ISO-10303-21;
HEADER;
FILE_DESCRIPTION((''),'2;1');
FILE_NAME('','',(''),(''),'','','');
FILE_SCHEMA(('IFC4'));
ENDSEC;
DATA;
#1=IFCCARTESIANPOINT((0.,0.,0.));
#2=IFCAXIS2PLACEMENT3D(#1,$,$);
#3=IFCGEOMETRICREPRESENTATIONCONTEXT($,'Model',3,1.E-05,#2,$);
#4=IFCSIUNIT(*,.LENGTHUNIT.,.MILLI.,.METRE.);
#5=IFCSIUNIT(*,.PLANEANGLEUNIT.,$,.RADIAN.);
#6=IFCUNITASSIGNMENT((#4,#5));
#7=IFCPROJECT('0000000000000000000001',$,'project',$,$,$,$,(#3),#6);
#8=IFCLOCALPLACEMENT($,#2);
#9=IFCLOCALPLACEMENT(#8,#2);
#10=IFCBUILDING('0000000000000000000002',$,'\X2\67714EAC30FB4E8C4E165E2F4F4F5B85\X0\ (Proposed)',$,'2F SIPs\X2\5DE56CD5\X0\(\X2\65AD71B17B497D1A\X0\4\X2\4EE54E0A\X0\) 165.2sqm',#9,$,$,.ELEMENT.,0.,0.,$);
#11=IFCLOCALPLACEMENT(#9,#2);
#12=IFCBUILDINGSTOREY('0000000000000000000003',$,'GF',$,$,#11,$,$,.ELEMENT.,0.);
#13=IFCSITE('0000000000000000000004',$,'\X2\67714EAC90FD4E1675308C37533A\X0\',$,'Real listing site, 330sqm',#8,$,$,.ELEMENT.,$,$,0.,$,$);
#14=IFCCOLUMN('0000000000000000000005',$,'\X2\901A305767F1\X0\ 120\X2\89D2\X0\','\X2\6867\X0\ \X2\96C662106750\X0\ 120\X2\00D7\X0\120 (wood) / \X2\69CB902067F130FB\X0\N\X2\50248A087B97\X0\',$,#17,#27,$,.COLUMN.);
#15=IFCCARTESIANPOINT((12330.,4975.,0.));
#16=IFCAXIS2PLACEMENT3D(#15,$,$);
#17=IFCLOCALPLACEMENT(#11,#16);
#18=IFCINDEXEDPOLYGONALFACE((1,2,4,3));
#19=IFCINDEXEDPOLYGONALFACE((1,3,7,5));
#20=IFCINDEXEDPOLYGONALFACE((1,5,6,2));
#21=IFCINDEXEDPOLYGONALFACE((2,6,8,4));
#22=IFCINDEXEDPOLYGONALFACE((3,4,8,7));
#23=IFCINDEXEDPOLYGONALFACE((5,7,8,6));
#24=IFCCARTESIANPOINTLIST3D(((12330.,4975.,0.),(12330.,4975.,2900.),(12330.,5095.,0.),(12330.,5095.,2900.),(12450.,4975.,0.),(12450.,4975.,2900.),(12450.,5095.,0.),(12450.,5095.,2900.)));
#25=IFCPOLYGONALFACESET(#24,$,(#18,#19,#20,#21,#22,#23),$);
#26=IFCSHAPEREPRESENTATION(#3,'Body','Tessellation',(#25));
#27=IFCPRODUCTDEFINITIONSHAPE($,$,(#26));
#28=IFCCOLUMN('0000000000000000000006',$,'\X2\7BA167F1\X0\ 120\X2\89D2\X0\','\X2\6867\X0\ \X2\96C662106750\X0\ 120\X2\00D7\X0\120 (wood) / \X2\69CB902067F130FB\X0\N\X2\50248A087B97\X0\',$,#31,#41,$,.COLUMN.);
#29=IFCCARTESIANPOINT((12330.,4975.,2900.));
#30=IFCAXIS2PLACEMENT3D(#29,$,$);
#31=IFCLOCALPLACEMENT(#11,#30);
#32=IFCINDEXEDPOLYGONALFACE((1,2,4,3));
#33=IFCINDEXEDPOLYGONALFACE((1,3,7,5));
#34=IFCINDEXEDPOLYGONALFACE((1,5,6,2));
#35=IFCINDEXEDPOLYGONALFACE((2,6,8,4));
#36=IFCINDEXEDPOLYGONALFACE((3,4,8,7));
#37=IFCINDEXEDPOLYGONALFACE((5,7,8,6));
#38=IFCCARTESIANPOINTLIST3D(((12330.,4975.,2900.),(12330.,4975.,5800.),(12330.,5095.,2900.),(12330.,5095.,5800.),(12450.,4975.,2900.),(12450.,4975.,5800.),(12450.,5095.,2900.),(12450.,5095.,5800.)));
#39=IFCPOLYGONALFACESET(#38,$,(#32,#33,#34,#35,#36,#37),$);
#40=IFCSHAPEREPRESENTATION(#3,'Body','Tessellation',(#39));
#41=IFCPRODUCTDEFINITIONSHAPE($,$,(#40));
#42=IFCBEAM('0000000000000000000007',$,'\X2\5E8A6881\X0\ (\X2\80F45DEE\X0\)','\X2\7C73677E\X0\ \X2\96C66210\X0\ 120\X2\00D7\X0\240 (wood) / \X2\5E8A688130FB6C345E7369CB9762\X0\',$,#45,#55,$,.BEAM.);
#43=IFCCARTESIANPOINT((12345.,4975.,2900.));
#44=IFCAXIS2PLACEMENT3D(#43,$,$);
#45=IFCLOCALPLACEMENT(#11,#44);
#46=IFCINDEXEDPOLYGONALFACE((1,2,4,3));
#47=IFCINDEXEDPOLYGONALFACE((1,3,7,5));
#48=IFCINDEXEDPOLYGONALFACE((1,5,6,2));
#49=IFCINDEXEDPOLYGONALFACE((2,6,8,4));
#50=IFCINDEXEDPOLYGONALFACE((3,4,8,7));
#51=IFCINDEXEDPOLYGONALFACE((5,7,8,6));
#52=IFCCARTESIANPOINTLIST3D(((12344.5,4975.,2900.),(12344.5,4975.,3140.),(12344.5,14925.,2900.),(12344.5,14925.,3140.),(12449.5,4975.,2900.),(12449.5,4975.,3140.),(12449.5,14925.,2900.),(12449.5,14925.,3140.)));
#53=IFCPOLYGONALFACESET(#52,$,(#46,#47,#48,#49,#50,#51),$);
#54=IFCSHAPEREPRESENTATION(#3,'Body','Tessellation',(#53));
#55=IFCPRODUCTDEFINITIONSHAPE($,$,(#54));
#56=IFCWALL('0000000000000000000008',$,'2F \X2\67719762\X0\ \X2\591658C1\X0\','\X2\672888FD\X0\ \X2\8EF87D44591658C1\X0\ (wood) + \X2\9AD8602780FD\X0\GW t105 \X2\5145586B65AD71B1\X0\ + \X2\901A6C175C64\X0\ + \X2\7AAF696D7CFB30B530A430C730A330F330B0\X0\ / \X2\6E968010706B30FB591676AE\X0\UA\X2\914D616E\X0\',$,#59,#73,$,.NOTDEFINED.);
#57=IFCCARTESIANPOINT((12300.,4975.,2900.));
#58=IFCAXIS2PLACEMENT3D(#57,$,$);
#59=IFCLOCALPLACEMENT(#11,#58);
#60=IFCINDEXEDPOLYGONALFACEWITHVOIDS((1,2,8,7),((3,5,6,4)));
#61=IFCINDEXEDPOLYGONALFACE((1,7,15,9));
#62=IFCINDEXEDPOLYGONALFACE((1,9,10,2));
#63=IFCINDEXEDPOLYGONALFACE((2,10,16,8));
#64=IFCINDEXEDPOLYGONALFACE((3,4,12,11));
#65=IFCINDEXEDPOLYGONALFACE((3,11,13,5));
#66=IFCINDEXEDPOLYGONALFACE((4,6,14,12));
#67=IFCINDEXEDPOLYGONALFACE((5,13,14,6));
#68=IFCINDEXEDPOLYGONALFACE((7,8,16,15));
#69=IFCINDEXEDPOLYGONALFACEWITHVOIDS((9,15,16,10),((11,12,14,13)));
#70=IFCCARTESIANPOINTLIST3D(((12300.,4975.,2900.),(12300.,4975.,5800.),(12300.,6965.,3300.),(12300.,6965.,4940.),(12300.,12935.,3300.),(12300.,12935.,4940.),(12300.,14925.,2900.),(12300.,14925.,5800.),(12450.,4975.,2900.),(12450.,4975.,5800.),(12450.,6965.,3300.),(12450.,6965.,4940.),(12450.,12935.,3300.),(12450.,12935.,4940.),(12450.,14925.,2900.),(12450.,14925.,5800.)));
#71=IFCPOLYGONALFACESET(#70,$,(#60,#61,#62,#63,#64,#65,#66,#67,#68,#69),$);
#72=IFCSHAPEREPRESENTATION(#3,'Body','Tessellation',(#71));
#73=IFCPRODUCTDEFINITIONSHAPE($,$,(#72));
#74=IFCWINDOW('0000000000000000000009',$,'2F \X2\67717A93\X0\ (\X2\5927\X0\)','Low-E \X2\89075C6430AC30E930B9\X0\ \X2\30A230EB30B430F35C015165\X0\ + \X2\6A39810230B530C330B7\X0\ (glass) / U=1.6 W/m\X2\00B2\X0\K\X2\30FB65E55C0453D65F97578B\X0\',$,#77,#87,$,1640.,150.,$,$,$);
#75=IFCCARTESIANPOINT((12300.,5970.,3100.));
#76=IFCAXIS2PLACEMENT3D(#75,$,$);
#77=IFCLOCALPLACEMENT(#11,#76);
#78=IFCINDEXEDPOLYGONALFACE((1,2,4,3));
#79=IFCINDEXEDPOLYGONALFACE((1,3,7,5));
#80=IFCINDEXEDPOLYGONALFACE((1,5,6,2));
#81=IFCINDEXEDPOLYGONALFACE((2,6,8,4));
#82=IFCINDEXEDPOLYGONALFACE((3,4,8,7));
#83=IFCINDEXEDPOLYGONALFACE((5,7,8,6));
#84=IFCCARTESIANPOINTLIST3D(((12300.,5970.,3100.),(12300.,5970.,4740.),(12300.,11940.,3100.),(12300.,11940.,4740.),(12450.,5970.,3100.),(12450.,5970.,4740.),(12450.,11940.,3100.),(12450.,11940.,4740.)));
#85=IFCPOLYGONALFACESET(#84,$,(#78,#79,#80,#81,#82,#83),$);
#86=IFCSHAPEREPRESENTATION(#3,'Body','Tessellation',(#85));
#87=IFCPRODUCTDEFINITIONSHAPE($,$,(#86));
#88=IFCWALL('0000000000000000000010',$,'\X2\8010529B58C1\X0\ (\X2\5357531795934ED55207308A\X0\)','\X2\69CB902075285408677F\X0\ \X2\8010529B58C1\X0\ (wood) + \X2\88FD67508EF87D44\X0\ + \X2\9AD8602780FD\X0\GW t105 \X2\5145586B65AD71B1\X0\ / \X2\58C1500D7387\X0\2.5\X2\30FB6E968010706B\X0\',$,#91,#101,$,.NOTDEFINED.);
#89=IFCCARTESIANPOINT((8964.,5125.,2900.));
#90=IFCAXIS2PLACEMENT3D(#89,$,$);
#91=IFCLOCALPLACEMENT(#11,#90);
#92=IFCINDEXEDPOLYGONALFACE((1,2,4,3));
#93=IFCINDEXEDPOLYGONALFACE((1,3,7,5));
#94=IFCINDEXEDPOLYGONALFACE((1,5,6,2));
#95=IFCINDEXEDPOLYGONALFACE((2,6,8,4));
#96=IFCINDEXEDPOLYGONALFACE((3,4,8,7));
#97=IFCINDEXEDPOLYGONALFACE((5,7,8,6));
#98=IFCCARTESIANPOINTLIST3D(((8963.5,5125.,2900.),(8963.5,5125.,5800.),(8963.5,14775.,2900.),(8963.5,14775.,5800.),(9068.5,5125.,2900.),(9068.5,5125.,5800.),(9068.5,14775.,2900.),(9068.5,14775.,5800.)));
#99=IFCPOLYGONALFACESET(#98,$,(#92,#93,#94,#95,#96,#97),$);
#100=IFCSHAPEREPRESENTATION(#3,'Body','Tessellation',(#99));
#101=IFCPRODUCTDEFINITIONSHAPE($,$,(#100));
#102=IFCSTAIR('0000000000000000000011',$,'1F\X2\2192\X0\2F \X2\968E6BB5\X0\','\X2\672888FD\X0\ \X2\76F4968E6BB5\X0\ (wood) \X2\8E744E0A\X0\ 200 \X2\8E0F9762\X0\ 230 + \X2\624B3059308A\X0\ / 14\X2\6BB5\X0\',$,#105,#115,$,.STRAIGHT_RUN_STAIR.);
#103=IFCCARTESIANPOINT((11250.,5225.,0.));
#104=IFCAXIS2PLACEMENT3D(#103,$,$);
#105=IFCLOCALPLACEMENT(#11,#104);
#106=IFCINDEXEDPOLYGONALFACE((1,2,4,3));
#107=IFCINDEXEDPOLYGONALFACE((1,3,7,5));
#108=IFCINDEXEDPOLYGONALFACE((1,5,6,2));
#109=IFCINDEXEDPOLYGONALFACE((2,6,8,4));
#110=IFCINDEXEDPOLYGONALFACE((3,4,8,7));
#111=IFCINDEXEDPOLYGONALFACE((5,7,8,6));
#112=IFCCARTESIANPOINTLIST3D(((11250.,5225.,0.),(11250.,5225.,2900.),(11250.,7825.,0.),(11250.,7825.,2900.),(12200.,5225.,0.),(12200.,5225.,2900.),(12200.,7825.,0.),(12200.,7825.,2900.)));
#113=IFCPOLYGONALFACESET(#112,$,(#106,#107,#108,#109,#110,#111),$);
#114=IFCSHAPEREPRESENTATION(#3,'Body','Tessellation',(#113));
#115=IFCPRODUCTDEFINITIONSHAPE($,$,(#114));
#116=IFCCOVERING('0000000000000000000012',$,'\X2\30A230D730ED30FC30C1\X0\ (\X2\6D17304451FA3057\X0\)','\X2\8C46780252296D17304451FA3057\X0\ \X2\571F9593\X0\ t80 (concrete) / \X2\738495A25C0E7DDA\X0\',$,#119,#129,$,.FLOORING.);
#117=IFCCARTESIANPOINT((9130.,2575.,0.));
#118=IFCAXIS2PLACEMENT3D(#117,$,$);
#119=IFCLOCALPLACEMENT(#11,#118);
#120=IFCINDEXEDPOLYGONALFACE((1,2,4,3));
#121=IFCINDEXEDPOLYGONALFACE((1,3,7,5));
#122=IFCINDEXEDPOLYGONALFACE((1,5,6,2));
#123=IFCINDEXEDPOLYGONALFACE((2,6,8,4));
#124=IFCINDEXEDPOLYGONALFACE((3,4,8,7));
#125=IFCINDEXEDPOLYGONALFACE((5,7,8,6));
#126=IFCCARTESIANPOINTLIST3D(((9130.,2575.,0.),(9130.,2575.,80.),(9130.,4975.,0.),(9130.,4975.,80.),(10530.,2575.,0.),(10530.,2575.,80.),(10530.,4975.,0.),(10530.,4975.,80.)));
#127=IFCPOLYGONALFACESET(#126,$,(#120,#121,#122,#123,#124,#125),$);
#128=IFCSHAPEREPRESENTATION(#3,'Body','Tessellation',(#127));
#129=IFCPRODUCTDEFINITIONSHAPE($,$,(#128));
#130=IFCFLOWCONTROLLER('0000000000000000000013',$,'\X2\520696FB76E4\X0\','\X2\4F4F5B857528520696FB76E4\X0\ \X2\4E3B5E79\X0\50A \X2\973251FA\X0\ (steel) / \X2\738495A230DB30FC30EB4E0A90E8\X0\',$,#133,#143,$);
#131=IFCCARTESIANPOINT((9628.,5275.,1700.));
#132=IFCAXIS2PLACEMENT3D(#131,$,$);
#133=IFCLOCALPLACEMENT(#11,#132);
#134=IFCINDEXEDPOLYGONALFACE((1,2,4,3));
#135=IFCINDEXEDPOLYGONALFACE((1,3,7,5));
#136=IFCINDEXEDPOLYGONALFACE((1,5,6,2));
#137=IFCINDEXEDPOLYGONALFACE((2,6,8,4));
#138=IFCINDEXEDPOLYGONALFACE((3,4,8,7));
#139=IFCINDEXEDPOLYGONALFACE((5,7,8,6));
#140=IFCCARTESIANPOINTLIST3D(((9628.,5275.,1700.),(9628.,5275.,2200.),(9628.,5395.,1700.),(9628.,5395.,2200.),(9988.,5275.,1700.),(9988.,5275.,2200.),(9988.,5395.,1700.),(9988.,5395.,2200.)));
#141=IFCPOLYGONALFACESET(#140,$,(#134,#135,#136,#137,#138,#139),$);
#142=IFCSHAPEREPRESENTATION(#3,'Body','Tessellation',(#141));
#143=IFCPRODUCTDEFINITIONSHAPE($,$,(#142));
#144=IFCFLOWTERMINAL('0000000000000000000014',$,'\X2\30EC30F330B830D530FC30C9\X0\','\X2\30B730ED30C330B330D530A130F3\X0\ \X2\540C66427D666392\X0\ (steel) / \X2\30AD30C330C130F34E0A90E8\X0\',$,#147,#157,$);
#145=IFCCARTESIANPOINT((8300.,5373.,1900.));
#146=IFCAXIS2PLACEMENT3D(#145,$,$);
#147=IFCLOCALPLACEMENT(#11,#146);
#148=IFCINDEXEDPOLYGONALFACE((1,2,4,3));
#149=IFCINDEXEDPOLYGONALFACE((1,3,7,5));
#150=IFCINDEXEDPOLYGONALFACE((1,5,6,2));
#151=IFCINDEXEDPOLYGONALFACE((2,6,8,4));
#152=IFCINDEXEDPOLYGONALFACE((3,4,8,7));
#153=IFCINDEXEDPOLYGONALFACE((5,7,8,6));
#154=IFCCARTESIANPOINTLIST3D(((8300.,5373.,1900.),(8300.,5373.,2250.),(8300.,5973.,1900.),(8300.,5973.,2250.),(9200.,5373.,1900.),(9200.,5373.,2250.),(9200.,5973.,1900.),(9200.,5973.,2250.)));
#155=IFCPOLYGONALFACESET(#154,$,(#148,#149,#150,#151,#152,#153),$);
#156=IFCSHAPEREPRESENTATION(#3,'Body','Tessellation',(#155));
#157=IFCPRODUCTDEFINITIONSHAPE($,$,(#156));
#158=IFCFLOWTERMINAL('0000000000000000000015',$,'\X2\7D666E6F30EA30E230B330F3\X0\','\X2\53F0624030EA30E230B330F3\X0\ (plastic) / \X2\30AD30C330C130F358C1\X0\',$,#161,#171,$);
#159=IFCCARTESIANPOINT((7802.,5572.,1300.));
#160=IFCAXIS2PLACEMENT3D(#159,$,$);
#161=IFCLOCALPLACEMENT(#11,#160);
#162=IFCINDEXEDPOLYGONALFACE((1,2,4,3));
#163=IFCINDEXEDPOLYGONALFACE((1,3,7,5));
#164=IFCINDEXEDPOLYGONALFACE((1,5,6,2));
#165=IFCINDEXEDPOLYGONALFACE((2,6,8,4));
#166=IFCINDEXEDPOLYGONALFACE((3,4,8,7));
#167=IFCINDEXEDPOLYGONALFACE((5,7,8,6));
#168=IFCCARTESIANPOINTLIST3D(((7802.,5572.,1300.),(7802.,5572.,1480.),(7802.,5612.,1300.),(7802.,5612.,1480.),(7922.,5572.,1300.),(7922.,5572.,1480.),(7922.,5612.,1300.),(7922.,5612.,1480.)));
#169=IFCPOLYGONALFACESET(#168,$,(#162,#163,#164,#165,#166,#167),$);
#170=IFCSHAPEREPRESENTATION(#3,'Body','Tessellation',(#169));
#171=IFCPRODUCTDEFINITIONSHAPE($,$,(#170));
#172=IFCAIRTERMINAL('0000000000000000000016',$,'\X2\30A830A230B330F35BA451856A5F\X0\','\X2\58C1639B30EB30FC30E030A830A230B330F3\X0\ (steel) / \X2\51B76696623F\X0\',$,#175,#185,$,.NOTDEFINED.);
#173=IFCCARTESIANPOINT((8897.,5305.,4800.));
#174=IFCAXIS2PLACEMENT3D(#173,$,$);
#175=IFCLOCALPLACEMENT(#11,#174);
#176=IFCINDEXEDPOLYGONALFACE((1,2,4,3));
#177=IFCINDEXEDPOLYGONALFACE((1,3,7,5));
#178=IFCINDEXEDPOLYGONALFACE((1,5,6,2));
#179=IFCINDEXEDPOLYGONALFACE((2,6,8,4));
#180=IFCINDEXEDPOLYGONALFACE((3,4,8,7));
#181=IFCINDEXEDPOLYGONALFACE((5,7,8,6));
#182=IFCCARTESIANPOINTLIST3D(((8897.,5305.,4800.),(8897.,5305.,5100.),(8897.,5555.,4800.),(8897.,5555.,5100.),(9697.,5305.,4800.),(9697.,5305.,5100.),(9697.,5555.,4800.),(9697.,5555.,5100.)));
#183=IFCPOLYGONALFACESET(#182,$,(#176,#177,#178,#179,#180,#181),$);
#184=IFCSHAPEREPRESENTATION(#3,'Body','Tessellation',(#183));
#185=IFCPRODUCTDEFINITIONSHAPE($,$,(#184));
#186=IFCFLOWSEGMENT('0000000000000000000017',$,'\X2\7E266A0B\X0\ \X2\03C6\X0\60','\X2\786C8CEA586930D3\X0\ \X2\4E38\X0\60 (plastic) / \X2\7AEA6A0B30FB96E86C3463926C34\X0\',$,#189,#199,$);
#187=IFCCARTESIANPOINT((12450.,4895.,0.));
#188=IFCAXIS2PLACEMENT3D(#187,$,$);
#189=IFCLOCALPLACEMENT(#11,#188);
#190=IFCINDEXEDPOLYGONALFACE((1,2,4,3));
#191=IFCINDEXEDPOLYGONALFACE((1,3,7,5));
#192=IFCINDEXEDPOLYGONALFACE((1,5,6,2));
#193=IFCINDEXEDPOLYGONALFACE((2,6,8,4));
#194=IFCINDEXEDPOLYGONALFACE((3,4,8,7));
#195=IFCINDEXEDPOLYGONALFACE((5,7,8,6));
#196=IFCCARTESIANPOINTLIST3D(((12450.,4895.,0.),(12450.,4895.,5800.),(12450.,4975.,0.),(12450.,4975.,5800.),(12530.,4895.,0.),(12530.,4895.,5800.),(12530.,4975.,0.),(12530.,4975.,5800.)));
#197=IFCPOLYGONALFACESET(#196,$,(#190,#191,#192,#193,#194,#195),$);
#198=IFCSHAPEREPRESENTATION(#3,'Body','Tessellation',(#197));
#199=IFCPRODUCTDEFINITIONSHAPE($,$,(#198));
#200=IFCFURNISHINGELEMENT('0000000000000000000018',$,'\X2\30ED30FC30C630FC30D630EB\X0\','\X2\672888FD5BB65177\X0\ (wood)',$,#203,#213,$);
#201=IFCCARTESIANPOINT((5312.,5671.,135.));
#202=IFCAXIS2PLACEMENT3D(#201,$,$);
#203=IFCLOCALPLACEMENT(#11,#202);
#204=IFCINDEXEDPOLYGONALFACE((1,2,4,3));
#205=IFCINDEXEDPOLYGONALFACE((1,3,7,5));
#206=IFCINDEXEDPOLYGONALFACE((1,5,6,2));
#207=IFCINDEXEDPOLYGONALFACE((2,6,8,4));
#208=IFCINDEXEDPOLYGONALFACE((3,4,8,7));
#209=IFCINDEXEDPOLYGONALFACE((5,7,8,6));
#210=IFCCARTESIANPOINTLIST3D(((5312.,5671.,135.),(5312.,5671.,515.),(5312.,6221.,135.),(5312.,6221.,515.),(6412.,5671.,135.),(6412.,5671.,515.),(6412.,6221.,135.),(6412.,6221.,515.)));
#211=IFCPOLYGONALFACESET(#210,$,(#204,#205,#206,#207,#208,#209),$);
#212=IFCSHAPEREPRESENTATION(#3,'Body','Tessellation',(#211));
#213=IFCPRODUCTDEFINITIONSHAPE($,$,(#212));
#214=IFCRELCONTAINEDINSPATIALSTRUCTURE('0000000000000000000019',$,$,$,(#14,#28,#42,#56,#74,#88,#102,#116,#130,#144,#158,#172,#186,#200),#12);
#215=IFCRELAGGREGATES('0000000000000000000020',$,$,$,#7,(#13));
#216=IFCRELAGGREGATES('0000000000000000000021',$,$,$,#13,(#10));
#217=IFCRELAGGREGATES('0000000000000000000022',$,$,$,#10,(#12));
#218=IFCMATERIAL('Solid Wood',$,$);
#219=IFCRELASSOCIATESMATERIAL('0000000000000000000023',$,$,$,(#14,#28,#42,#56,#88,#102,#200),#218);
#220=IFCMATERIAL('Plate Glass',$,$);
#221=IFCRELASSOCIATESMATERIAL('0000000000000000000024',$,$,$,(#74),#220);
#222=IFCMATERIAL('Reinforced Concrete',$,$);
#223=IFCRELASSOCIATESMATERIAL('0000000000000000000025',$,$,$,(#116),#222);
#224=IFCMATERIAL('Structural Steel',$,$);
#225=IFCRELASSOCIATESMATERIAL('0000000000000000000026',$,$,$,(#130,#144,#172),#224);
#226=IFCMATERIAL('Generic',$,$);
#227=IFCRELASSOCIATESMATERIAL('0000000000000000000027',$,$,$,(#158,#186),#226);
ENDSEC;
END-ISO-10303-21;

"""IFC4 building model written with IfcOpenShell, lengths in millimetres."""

from ifc_helpers import new_model, si_unit, frame, frame_2d, origin, place, context, project, spatial, rectangle, extrude, material, element, fill, save


model = new_model("IFC4")

# Units and contexts
model_context = context("Model", 3, precision=1e-05, world=origin())
ifc_project = project(units=[si_unit("LENGTHUNIT", "METRE", prefix="MILLI"), si_unit("PLANEANGLEUNIT", "RADIAN")], contexts=[model_context])

# Site, building, storey
site_placement = place(None, origin())
site = spatial("IfcSite", under=ifc_project, at=site_placement, Name="東京都世田谷区", ObjectType="Real listing site, 330sqm", CompositionType="ELEMENT", RefElevation=0.0)
building_placement = place(site_placement, origin())
building = spatial("IfcBuilding", under=site, at=building_placement, Name="東京・二世帯住宅 (Proposed)", ObjectType="2F SIPs工法(断熱等級4以上) 165.2sqm", CompositionType="ELEMENT", ElevationOfRefHeight=0.0, ElevationOfTerrain=0.0)
storey_placement = place(building_placement, origin())
storey = spatial("IfcBuildingStorey", under=building, at=storey_placement, Name="GF", CompositionType="ELEMENT", Elevation=0.0)

# Columns
ifc_material_1 = material(Name="Solid Wood")
column_1_placement = place(storey_placement, frame((12330.0, 4975.0, 0.0)))
element("IfcColumn", 1, at=column_1_placement, inside=storey, material=ifc_material_1, Name="通し柱 120角", Description="桧 集成材 120×120 (wood) / 構造柱・N値計算", PredefinedType="COLUMN", context=model_context, shape_type="SweptSolid", body=[
    extrude(rectangle(XDim=120.0, YDim=120.0, at=frame_2d((60.0, 60.0))), frame((12330.0, 4975.0, 0.0)), (0.0, 0.0, 1.0), 2900.0),
])
column_2_placement = place(storey_placement, frame((12330.0, 4975.0, 2900.0)))
element("IfcColumn", 2, at=column_2_placement, inside=storey, material=ifc_material_1, Name="管柱 120角", Description="桧 集成材 120×120 (wood) / 構造柱・N値計算", PredefinedType="COLUMN", context=model_context, shape_type="SweptSolid", body=[
    extrude(rectangle(XDim=120.0, YDim=120.0, at=frame_2d((60.0, 60.0))), frame((12330.0, 4975.0, 2900.0)), (0.0, 0.0, 1.0), 2900.0),
])

# Beam
beam_1_placement = place(storey_placement, frame((12345.0, 4975.0, 2900.0)))
element("IfcBeam", 3, at=beam_1_placement, inside=storey, material=ifc_material_1, Name="床梁 (胴差)", Description="米松 集成 120×240 (wood) / 床梁・水平構面", PredefinedType="BEAM", context=model_context, shape_type="SweptSolid", body=[
    extrude(rectangle(XDim=105.0, YDim=9950.0, at=frame_2d((52.0, 4975.0))), frame((12345.0, 4975.0, 2900.0)), (0.0, 0.0, 1.0), 240.0),
])

# Shared definitions
ifc_material_2 = material(Name="Plate Glass")

# Wall, opening, window
wall_1_placement = place(storey_placement, frame((12300.0, 4975.0, 2900.0)))
wall_1 = element("IfcWall", 4, at=wall_1_placement, inside=storey, material=ifc_material_1, Name="2F 東面 外壁", Description="木製 軸組外壁 (wood) + 高性能GW t105 充填断熱 + 通気層 + 窯業系サイディング / 準耐火・外皮UA配慮", PredefinedType="NOTDEFINED", context=model_context, shape_type="SweptSolid", body=[
    extrude(rectangle(XDim=150.0, YDim=9950.0, at=frame_2d((75.0, 4975.0))), frame((12300.0, 4975.0, 2900.0)), (0.0, 0.0, 1.0), 2900.0),
])
opening_1_placement = place(storey_placement, frame((12300.0, 5970.0, 3100.0)))
opening_1 = element("IfcOpeningElement", 5, at=opening_1_placement, cuts=wall_1, PredefinedType="NOTDEFINED", context=model_context, shape_type="SweptSolid", body=[
    extrude(rectangle(XDim=150.0, YDim=5970.0, at=frame_2d((75.0, 2985.0))), frame((12300.0, 5970.0, 3100.0)), (0.0, 0.0, 1.0), 1640.0),
])
window_1_placement = place(storey_placement, frame((12300.0, 5970.0, 3100.0)))
window_1 = element("IfcWindow", 6, at=window_1_placement, inside=storey, material=ifc_material_2, Name="2F 東窓 (大)", Description="Low-E 複層ガラス アルゴン封入 + 樹脂サッシ (glass) / U=1.6 W/m²K・日射取得型", OverallHeight=1640.0, OverallWidth=150.0, context=model_context, shape_type="SweptSolid", body=[
    extrude(rectangle(XDim=150.0, YDim=5970.0, at=frame_2d((75.0, 2985.0))), frame((12300.0, 5970.0, 3100.0)), (0.0, 0.0, 1.0), 1640.0),
])
fill(opening_1, window_1)

# Wall
wall_2_placement = place(storey_placement, frame((8964.0, 5125.0, 2900.0)))
element("IfcWall", 7, at=wall_2_placement, inside=storey, material=ifc_material_1, Name="耐力壁 (南北間仕切り)", Description="構造用合板 耐力壁 (wood) + 製材軸組 + 高性能GW t105 充填断熱 / 壁倍率2.5・準耐火", PredefinedType="NOTDEFINED", context=model_context, shape_type="SweptSolid", body=[
    extrude(rectangle(XDim=105.0, YDim=9650.0, at=frame_2d((52.0, 4825.0))), frame((8964.0, 5125.0, 2900.0)), (0.0, 0.0, 1.0), 2900.0),
])

# Stair
stair_placement = place(storey_placement, frame((11250.0, 5225.0, 0.0)))
element("IfcStair", 8, at=stair_placement, inside=storey, material=ifc_material_1, Name="1F→2F 階段", Description="木製 直階段 (wood) 蹴上 200 踏面 230 + 手すり / 14段", PredefinedType="STRAIGHT_RUN_STAIR", context=model_context, shape_type="SweptSolid", body=[
    extrude(rectangle(XDim=950.0, YDim=2600.0, at=frame_2d((475.0, 1300.0))), frame((11250.0, 5225.0, 0.0)), (0.0, 0.0, 1.0), 2900.0),
])

# Covering
ifc_material_3 = material(Name="Reinforced Concrete")
covering_placement = place(storey_placement, frame((9130.0, 2575.0, 0.0)))
element("IfcCovering", 9, at=covering_placement, inside=storey, material=ifc_material_3, Name="アプローチ (洗い出し)", Description="豆砂利洗い出し 土間 t80 (concrete) / 玄関導線", PredefinedType="FLOORING", context=model_context, shape_type="SweptSolid", body=[
    extrude(rectangle(XDim=1400.0, YDim=2400.0, at=frame_2d((700.0, 1200.0))), frame((9130.0, 2575.0, 0.0)), (0.0, 0.0, 1.0), 80.0),
])

# Flow controller
ifc_material_4 = material(Name="Structural Steel")
flow_controller_placement = place(storey_placement, frame((9628.0, 5275.0, 1700.0)))
element("IfcFlowController", 10, at=flow_controller_placement, inside=storey, material=ifc_material_4, Name="分電盤", Description="住宅用分電盤 主幹50A 露出 (steel) / 玄関ホール上部", context=model_context, shape_type="SweptSolid", body=[
    extrude(rectangle(XDim=360.0, YDim=120.0, at=frame_2d((180.0, 60.0))), frame((9628.0, 5275.0, 1700.0)), (0.0, 0.0, 1.0), 500.0),
])

# Flow terminals
flow_terminal_1_placement = place(storey_placement, frame((8300.0, 5373.0, 1900.0)))
element("IfcFlowTerminal", 11, at=flow_terminal_1_placement, inside=storey, material=ifc_material_4, Name="レンジフード", Description="シロッコファン 同時給排 (steel) / キッチン上部", context=model_context, shape_type="SweptSolid", body=[
    extrude(rectangle(XDim=900.0, YDim=600.0, at=frame_2d((450.0, 300.0))), frame((8300.0, 5373.0, 1900.0)), (0.0, 0.0, 1.0), 350.0),
])
ifc_material_5 = material(Name="Generic")
flow_terminal_2_placement = place(storey_placement, frame((7802.0, 5572.0, 1300.0)))
element("IfcFlowTerminal", 12, at=flow_terminal_2_placement, inside=storey, material=ifc_material_5, Name="給湯リモコン", Description="台所リモコン (plastic) / キッチン壁", context=model_context, shape_type="SweptSolid", body=[
    extrude(rectangle(XDim=120.0, YDim=40.0, at=frame_2d((60.0, 20.0))), frame((7802.0, 5572.0, 1300.0)), (0.0, 0.0, 1.0), 180.0),
])

# Air terminal
air_terminal_placement = place(storey_placement, frame((8897.0, 5305.0, 4800.0)))
element("IfcAirTerminal", 13, at=air_terminal_placement, inside=storey, material=ifc_material_4, Name="エアコン室内機", Description="壁掛ルームエアコン (steel) / 冷暖房", PredefinedType="NOTDEFINED", context=model_context, shape_type="SweptSolid", body=[
    extrude(rectangle(XDim=800.0, YDim=250.0, at=frame_2d((400.0, 125.0))), frame((8897.0, 5305.0, 4800.0)), (0.0, 0.0, 1.0), 300.0),
])

# Flow segment
flow_segment_placement = place(storey_placement, frame((12450.0, 4895.0, 0.0)))
element("IfcFlowSegment", 14, at=flow_segment_placement, inside=storey, material=ifc_material_5, Name="縦樋 φ60", Description="硬質塩ビ 丸60 (plastic) / 竪樋・雨水排水", context=model_context, shape_type="SweptSolid", body=[
    extrude(rectangle(XDim=80.0, YDim=80.0, at=frame_2d((40.0, 40.0))), frame((12450.0, 4895.0, 0.0)), (0.0, 0.0, 1.0), 5800.0),
])

# Furnishing element
furnishing_1_placement = place(storey_placement, frame((5312.0, 5671.0, 135.0)))
element("IfcFurnishingElement", 15, at=furnishing_1_placement, inside=storey, material=ifc_material_1, Name="ローテーブル", Description="木製家具 (wood)", context=model_context, shape_type="SweptSolid", body=[
    extrude(rectangle(XDim=1100.0, YDim=550.0, at=frame_2d((550.0, 275.0))), frame((5312.0, 5671.0, 135.0)), (0.0, 0.0, 1.0), 380.0),
])

save(model, "model.ifc")
